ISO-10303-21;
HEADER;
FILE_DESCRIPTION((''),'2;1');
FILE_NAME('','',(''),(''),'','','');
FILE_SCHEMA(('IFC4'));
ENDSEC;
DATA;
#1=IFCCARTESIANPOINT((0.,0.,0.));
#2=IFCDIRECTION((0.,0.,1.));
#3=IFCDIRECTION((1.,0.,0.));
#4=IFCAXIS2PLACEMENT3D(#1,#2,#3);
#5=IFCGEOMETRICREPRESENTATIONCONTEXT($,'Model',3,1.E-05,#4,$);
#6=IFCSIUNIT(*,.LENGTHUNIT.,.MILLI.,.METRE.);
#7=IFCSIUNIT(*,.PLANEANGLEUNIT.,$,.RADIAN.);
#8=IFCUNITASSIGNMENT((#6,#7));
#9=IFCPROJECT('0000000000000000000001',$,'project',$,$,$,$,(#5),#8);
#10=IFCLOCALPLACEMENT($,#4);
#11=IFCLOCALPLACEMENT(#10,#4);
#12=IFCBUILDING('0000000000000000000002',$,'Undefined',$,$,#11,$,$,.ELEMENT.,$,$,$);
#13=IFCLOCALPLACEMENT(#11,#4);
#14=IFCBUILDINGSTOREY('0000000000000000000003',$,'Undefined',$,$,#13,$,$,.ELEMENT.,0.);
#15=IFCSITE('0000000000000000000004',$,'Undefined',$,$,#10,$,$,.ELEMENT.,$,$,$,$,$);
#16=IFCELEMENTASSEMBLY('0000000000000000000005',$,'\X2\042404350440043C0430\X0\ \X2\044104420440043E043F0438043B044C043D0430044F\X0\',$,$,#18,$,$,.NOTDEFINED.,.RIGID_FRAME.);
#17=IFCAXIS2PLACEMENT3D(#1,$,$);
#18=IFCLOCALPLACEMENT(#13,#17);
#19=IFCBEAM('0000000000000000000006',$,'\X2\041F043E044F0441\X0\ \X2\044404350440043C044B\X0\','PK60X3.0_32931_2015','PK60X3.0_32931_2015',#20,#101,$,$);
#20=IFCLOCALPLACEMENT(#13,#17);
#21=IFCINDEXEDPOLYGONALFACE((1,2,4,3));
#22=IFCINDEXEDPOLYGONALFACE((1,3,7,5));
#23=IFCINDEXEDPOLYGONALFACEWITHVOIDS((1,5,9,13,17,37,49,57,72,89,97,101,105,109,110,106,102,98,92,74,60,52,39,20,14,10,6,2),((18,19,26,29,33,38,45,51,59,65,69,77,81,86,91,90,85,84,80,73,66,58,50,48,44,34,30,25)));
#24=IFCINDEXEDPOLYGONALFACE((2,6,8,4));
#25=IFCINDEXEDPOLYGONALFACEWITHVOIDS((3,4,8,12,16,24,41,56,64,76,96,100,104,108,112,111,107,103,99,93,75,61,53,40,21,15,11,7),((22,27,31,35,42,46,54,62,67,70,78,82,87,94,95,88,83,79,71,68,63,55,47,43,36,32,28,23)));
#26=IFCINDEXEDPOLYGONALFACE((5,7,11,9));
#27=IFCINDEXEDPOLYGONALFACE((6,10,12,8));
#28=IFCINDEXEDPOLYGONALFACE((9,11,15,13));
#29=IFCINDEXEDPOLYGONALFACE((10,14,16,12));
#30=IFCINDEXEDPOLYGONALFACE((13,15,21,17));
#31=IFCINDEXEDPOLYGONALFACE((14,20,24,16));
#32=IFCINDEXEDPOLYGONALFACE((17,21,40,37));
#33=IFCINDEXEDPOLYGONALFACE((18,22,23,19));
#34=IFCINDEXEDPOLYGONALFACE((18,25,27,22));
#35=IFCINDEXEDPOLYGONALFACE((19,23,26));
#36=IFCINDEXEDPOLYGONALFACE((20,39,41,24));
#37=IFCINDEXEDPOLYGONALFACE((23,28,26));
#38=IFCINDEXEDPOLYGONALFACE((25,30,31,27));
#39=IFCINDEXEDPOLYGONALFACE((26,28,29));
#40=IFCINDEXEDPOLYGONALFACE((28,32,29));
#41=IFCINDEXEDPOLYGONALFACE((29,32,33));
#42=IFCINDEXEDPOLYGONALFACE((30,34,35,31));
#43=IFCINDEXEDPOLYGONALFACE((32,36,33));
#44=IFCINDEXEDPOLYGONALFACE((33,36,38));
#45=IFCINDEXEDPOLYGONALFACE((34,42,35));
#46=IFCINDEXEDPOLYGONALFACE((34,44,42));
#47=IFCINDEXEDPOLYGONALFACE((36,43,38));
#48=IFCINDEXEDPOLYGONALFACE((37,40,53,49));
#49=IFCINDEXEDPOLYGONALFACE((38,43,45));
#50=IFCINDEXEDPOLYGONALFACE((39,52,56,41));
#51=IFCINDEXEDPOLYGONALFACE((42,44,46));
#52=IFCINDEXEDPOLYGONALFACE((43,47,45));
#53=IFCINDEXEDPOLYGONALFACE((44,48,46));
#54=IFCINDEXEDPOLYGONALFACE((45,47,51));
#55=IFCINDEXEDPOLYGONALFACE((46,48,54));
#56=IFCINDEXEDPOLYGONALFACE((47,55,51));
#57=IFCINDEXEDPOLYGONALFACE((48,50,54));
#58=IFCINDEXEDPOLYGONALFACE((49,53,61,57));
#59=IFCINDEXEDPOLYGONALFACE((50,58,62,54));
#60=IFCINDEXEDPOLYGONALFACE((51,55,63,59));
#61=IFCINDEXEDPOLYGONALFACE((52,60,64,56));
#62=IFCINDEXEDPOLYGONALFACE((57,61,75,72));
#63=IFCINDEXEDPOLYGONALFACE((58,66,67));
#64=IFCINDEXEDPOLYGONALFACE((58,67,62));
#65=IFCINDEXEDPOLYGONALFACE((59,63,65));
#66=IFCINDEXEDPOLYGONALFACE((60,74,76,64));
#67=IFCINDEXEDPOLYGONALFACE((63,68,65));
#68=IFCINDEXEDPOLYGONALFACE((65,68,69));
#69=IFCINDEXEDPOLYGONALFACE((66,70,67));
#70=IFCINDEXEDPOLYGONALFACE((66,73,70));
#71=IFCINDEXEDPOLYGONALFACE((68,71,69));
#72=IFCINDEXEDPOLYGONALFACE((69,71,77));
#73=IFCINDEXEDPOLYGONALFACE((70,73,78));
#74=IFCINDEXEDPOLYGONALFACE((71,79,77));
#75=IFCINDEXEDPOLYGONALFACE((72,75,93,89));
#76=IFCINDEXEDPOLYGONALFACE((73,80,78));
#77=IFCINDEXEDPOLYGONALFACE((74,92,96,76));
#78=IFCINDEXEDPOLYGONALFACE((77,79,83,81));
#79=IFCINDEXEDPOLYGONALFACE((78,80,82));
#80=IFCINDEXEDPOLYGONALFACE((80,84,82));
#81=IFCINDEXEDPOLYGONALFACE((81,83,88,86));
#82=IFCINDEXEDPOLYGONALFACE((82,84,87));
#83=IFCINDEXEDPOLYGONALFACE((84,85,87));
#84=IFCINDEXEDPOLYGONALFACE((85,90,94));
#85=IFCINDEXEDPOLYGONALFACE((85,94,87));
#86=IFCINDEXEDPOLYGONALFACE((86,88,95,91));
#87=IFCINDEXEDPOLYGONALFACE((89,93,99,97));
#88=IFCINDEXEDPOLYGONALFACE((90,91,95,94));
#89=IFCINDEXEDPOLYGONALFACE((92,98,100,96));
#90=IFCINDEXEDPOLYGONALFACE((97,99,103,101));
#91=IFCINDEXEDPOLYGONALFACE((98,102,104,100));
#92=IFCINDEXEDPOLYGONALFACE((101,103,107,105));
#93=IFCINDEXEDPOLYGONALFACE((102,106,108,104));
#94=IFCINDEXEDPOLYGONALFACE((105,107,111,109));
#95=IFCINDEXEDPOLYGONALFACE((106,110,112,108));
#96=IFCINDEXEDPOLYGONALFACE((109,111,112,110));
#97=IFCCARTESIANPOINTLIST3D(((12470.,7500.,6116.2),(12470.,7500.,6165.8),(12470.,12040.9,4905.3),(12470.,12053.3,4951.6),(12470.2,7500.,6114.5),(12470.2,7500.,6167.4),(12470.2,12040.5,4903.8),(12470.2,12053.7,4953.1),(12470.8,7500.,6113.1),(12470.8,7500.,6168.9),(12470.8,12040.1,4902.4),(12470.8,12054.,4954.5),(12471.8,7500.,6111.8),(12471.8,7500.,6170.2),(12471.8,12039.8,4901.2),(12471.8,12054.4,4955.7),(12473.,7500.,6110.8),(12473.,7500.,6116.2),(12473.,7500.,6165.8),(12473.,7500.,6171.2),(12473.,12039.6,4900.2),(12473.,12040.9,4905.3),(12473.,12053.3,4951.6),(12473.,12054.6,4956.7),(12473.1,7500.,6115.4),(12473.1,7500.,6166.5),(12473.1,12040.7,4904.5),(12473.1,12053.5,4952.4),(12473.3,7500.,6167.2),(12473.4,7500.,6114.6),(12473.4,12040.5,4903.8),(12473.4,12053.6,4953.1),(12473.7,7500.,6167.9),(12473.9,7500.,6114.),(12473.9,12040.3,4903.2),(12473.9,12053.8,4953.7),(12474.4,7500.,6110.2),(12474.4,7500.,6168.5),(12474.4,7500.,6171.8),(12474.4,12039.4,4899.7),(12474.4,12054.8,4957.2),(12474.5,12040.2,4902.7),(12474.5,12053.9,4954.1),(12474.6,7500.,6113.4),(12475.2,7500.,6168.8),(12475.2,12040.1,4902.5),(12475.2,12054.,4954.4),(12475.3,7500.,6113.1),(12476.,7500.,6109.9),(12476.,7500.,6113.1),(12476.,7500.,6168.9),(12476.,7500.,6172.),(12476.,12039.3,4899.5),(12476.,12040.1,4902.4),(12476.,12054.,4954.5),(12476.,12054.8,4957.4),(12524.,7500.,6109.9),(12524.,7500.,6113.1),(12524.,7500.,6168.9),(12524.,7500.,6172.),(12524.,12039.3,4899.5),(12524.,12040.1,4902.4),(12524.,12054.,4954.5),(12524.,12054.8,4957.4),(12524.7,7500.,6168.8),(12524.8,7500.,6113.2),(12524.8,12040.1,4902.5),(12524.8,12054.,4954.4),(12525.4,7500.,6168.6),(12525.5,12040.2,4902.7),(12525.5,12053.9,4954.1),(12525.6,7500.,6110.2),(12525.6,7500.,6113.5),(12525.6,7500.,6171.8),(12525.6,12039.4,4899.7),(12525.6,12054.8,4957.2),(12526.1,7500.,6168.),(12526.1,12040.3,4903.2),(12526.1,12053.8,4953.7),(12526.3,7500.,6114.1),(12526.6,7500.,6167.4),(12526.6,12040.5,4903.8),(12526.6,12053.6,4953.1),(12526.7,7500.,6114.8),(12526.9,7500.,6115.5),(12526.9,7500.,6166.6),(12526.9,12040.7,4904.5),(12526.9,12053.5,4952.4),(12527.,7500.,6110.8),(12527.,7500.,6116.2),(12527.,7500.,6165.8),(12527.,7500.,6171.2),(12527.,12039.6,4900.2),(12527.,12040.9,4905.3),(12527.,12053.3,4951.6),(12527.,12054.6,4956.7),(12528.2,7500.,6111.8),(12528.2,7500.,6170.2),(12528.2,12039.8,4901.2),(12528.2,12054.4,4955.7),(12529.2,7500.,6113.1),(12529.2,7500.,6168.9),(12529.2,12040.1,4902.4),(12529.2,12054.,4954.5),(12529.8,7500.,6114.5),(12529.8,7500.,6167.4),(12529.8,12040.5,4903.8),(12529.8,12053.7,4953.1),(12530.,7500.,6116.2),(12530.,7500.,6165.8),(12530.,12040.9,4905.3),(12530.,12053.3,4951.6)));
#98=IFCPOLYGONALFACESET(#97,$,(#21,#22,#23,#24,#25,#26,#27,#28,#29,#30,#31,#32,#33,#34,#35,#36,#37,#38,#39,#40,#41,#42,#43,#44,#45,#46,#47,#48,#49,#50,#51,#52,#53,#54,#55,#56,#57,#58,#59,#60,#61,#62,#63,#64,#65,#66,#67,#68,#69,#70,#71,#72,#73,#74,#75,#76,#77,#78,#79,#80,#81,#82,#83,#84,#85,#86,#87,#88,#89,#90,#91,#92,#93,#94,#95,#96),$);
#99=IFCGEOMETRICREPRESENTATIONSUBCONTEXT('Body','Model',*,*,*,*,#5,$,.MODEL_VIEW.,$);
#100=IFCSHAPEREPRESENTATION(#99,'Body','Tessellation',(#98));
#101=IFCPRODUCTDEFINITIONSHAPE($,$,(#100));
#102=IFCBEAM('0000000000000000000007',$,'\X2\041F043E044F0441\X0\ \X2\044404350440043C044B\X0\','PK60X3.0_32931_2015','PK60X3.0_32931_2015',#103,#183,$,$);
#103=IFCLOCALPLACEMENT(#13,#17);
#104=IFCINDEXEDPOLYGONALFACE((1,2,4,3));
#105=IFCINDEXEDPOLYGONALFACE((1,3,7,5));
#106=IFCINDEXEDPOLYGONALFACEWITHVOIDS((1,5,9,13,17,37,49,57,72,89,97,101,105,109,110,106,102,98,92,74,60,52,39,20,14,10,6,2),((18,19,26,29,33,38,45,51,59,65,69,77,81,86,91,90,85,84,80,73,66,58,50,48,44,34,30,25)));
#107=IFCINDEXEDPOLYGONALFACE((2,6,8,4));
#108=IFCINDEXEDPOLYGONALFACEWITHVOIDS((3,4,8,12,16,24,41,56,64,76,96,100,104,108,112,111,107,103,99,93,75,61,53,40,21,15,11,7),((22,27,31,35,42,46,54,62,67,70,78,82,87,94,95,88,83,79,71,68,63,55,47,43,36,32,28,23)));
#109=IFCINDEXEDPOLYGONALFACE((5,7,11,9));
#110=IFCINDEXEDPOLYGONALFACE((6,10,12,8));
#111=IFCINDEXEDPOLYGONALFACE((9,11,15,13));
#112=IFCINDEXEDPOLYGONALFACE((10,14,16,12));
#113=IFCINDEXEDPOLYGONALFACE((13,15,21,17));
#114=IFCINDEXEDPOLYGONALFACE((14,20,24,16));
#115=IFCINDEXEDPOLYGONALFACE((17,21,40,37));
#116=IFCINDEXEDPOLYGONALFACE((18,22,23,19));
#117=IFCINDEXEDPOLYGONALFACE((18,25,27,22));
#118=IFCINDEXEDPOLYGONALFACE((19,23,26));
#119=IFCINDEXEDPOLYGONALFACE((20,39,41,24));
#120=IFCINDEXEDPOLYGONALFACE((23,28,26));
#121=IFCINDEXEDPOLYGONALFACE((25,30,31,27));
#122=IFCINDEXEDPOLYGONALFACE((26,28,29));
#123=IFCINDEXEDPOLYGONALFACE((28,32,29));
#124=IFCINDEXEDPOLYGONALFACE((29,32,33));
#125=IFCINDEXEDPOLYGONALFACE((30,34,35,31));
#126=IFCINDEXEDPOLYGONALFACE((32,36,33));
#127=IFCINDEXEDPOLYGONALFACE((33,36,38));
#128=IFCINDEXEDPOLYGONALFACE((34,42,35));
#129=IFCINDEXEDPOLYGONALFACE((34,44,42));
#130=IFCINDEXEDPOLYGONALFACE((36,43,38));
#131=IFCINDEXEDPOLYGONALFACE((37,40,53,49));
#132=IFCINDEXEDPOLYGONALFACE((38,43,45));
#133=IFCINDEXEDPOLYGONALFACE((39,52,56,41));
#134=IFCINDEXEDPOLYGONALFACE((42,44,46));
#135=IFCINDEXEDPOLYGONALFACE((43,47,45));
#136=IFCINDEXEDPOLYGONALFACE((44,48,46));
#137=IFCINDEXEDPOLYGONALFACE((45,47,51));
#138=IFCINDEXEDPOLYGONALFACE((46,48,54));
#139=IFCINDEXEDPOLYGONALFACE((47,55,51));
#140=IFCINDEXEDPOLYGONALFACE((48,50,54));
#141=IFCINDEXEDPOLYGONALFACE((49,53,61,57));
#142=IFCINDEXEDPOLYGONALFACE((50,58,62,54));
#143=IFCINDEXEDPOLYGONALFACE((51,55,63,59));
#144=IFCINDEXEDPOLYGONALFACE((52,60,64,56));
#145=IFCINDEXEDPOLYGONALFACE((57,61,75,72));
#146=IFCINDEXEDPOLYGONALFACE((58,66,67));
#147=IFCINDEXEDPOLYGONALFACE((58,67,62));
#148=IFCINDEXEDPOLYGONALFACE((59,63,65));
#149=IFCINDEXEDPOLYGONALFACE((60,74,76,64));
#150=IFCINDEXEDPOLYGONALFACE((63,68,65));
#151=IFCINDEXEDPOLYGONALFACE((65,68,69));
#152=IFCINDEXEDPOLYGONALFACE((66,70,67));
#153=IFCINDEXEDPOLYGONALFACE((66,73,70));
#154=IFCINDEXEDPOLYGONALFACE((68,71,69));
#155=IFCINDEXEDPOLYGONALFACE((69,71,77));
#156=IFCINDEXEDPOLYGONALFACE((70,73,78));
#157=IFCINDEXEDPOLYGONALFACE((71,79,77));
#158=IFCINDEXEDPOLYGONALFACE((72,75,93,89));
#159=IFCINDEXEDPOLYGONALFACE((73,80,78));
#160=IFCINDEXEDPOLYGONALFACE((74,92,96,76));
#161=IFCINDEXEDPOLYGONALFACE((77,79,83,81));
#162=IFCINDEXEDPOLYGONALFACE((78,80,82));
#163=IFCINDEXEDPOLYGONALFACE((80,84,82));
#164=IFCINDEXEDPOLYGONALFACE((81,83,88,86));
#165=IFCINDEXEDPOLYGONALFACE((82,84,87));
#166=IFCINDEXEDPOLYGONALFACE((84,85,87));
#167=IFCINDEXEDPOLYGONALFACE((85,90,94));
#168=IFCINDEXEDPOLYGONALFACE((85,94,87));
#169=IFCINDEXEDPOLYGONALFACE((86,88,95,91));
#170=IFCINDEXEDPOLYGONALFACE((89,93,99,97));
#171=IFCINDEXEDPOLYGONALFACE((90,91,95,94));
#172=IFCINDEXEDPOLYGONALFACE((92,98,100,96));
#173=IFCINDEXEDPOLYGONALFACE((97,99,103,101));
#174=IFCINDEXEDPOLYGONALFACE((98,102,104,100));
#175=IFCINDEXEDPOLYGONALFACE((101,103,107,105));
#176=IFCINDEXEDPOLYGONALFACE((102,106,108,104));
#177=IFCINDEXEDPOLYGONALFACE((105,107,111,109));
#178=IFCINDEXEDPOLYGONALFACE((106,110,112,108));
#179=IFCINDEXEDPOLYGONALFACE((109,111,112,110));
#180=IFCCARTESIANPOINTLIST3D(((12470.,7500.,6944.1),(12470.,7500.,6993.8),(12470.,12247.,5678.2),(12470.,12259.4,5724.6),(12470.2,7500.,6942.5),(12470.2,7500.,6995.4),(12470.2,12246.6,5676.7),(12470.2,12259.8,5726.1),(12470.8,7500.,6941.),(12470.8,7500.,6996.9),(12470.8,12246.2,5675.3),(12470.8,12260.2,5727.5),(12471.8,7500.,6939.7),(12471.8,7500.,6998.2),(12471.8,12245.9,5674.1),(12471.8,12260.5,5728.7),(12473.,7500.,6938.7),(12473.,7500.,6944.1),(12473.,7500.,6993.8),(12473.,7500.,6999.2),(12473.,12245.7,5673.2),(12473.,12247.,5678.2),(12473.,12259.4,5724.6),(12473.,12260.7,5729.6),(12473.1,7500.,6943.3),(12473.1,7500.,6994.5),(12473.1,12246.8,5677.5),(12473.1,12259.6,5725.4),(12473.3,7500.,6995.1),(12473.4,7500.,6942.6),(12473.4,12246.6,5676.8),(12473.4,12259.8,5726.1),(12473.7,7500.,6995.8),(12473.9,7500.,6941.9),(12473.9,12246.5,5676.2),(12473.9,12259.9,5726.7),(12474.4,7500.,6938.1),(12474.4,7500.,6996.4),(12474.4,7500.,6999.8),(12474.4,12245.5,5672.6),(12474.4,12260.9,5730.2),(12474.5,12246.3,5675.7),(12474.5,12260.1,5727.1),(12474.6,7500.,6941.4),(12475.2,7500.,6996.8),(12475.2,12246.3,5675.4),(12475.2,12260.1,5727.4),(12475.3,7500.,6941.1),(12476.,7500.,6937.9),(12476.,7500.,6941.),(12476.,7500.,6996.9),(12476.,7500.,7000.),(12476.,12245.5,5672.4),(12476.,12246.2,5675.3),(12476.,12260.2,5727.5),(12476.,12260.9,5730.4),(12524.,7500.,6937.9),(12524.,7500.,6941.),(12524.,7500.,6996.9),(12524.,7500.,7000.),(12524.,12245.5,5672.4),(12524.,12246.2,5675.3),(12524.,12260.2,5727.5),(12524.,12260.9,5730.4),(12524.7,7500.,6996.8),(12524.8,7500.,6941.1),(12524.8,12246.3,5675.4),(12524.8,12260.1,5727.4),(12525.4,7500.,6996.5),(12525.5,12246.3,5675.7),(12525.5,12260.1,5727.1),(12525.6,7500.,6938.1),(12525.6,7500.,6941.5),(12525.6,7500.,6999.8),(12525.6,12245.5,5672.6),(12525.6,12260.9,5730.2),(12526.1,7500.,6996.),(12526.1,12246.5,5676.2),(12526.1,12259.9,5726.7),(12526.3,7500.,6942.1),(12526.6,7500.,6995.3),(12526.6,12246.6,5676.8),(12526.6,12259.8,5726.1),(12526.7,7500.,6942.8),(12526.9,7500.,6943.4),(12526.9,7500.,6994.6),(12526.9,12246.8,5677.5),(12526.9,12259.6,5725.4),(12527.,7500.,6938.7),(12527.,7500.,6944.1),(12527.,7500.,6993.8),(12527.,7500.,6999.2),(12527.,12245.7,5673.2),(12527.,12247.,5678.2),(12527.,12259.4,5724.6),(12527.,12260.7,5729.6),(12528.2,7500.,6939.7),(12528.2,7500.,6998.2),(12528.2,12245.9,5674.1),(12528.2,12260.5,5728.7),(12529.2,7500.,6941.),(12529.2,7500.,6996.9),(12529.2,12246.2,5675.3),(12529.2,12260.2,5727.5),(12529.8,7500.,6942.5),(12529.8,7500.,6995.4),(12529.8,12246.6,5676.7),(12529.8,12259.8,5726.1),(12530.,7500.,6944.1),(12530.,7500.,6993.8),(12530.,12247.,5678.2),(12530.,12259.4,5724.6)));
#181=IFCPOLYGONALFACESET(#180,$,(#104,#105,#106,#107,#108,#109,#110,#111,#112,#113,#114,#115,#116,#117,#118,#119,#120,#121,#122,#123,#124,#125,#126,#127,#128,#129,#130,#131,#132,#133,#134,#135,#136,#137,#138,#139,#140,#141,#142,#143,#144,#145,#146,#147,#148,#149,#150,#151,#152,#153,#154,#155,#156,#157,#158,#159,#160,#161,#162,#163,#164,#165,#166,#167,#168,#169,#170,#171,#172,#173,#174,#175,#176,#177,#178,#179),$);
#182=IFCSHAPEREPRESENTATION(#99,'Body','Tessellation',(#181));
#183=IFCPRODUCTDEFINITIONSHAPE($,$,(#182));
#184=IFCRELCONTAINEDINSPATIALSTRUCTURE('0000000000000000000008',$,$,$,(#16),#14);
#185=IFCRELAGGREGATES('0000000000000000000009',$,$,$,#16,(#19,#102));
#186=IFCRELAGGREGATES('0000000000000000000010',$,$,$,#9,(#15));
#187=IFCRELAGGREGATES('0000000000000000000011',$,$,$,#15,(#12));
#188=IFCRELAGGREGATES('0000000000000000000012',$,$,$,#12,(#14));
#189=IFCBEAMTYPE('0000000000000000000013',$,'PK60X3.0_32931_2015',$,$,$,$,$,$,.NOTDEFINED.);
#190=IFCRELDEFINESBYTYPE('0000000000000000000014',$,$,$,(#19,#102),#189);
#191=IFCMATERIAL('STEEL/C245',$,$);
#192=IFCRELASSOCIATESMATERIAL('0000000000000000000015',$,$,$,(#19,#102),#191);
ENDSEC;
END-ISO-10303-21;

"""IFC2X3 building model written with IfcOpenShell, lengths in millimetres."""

from ifc_helpers import new_model, si_unit, frame, origin_with_axes, origin_2d_with_axis, place, context, subcontext, project, spatial, hollow_rectangle, extrude, clip, halfspace, material, type_object, element, aggregate, save


model = new_model("IFC2X3")

# Units and contexts
model_context = context("Model", 3, precision=1e-05, world=origin_with_axes())
body_context = subcontext(model_context, "Body", "Model", "MODEL_VIEW")
ifc_project = project(units=[si_unit("LENGTHUNIT", "METRE", prefix="MILLI"), si_unit("PLANEANGLEUNIT", "RADIAN")], contexts=[model_context])

# Site, building, storey
site_placement = place(None, origin_with_axes())
site = spatial("IfcSite", under=ifc_project, at=site_placement, Name="Undefined", CompositionType="ELEMENT")
building_placement = place(site_placement, origin_with_axes())
building = spatial("IfcBuilding", under=site, at=building_placement, Name="Undefined", CompositionType="ELEMENT")
storey_placement = place(building_placement, origin_with_axes())
storey = spatial("IfcBuildingStorey", under=building, at=storey_placement, Name="Undefined", CompositionType="ELEMENT", Elevation=0.0)

# Shared definitions
ifc_material_1 = material(Name="STEEL/C245")

# Shared definitions
beam_type_1 = type_object("IfcBeamType", Name="PK60X3.0_32931_2015", PredefinedType="NOTDEFINED")

# Element assembly, beams
assembly_1_placement = place(storey_placement, origin_with_axes())
assembly_1 = element("IfcElementAssembly", 1, at=assembly_1_placement, inside=storey, Name="Ферма стропильная", AssemblyPlace="NOTDEFINED", PredefinedType="RIGID_FRAME")
beam_1_placement = place(assembly_1_placement, frame((12500.0, 12047.1, 4928.4), z_axis=(0.0, 0.257663, 0.966235), x_axis=(0.0, -0.966235, 0.257663)))
beam_1 = element("IfcBeam", 2, at=beam_1_placement, type_object=beam_type_1, material=ifc_material_1, Name="Пояс фермы", Description="PK60X3.0_32931_2015", ObjectType="PK60X3.0_32931_2015", context=body_context, shape_type="Clipping", body=[
    clip(extrude(hollow_rectangle(XDim=60.0, YDim=60.0, WallThickness=3.0, InnerFilletRadius=3.0, OuterFilletRadius=6.0, at=origin_2d_with_axis()), frame((4729.1, 0.0, 0.0), z_axis=(-1.0, 0.0, 0.0), x_axis=(0.0, -1.0, 0.0)), (0.0, 0.0, 1.0), 4729.1), halfspace(frame((4938.1, 0.0, 870.5), z_axis=(0.966235, 0.0, -0.257663), x_axis=(0.257663, 0.0, 0.966235)), False)),
])
beam_2_placement = place(assembly_1_placement, frame((12500.0, 12253.2, 5701.4), z_axis=(0.0, 0.257663, 0.966235), x_axis=(0.0, -0.966235, 0.257663)))
beam_2 = element("IfcBeam", 3, at=beam_2_placement, type_object=beam_type_1, material=ifc_material_1, Name="Пояс фермы", Description="PK60X3.0_32931_2015", ObjectType="PK60X3.0_32931_2015", context=body_context, shape_type="Clipping", body=[
    clip(extrude(hollow_rectangle(XDim=60.0, YDim=60.0, WallThickness=3.0, InnerFilletRadius=3.0, OuterFilletRadius=6.0, at=origin_2d_with_axis()), frame((4942.5, 0.0, 0.0), z_axis=(-1.0, 0.0, 0.0), x_axis=(0.0, -1.0, 0.0)), (0.0, 0.0, 1.0), 4942.5), halfspace(frame((4938.1, 0.0, 70.5), z_axis=(0.966235, 0.0, -0.257663), x_axis=(0.257663, 0.0, 0.966235)), False)),
])

aggregate(assembly_1, [beam_1, beam_2])

save(model, "model.ifc")
